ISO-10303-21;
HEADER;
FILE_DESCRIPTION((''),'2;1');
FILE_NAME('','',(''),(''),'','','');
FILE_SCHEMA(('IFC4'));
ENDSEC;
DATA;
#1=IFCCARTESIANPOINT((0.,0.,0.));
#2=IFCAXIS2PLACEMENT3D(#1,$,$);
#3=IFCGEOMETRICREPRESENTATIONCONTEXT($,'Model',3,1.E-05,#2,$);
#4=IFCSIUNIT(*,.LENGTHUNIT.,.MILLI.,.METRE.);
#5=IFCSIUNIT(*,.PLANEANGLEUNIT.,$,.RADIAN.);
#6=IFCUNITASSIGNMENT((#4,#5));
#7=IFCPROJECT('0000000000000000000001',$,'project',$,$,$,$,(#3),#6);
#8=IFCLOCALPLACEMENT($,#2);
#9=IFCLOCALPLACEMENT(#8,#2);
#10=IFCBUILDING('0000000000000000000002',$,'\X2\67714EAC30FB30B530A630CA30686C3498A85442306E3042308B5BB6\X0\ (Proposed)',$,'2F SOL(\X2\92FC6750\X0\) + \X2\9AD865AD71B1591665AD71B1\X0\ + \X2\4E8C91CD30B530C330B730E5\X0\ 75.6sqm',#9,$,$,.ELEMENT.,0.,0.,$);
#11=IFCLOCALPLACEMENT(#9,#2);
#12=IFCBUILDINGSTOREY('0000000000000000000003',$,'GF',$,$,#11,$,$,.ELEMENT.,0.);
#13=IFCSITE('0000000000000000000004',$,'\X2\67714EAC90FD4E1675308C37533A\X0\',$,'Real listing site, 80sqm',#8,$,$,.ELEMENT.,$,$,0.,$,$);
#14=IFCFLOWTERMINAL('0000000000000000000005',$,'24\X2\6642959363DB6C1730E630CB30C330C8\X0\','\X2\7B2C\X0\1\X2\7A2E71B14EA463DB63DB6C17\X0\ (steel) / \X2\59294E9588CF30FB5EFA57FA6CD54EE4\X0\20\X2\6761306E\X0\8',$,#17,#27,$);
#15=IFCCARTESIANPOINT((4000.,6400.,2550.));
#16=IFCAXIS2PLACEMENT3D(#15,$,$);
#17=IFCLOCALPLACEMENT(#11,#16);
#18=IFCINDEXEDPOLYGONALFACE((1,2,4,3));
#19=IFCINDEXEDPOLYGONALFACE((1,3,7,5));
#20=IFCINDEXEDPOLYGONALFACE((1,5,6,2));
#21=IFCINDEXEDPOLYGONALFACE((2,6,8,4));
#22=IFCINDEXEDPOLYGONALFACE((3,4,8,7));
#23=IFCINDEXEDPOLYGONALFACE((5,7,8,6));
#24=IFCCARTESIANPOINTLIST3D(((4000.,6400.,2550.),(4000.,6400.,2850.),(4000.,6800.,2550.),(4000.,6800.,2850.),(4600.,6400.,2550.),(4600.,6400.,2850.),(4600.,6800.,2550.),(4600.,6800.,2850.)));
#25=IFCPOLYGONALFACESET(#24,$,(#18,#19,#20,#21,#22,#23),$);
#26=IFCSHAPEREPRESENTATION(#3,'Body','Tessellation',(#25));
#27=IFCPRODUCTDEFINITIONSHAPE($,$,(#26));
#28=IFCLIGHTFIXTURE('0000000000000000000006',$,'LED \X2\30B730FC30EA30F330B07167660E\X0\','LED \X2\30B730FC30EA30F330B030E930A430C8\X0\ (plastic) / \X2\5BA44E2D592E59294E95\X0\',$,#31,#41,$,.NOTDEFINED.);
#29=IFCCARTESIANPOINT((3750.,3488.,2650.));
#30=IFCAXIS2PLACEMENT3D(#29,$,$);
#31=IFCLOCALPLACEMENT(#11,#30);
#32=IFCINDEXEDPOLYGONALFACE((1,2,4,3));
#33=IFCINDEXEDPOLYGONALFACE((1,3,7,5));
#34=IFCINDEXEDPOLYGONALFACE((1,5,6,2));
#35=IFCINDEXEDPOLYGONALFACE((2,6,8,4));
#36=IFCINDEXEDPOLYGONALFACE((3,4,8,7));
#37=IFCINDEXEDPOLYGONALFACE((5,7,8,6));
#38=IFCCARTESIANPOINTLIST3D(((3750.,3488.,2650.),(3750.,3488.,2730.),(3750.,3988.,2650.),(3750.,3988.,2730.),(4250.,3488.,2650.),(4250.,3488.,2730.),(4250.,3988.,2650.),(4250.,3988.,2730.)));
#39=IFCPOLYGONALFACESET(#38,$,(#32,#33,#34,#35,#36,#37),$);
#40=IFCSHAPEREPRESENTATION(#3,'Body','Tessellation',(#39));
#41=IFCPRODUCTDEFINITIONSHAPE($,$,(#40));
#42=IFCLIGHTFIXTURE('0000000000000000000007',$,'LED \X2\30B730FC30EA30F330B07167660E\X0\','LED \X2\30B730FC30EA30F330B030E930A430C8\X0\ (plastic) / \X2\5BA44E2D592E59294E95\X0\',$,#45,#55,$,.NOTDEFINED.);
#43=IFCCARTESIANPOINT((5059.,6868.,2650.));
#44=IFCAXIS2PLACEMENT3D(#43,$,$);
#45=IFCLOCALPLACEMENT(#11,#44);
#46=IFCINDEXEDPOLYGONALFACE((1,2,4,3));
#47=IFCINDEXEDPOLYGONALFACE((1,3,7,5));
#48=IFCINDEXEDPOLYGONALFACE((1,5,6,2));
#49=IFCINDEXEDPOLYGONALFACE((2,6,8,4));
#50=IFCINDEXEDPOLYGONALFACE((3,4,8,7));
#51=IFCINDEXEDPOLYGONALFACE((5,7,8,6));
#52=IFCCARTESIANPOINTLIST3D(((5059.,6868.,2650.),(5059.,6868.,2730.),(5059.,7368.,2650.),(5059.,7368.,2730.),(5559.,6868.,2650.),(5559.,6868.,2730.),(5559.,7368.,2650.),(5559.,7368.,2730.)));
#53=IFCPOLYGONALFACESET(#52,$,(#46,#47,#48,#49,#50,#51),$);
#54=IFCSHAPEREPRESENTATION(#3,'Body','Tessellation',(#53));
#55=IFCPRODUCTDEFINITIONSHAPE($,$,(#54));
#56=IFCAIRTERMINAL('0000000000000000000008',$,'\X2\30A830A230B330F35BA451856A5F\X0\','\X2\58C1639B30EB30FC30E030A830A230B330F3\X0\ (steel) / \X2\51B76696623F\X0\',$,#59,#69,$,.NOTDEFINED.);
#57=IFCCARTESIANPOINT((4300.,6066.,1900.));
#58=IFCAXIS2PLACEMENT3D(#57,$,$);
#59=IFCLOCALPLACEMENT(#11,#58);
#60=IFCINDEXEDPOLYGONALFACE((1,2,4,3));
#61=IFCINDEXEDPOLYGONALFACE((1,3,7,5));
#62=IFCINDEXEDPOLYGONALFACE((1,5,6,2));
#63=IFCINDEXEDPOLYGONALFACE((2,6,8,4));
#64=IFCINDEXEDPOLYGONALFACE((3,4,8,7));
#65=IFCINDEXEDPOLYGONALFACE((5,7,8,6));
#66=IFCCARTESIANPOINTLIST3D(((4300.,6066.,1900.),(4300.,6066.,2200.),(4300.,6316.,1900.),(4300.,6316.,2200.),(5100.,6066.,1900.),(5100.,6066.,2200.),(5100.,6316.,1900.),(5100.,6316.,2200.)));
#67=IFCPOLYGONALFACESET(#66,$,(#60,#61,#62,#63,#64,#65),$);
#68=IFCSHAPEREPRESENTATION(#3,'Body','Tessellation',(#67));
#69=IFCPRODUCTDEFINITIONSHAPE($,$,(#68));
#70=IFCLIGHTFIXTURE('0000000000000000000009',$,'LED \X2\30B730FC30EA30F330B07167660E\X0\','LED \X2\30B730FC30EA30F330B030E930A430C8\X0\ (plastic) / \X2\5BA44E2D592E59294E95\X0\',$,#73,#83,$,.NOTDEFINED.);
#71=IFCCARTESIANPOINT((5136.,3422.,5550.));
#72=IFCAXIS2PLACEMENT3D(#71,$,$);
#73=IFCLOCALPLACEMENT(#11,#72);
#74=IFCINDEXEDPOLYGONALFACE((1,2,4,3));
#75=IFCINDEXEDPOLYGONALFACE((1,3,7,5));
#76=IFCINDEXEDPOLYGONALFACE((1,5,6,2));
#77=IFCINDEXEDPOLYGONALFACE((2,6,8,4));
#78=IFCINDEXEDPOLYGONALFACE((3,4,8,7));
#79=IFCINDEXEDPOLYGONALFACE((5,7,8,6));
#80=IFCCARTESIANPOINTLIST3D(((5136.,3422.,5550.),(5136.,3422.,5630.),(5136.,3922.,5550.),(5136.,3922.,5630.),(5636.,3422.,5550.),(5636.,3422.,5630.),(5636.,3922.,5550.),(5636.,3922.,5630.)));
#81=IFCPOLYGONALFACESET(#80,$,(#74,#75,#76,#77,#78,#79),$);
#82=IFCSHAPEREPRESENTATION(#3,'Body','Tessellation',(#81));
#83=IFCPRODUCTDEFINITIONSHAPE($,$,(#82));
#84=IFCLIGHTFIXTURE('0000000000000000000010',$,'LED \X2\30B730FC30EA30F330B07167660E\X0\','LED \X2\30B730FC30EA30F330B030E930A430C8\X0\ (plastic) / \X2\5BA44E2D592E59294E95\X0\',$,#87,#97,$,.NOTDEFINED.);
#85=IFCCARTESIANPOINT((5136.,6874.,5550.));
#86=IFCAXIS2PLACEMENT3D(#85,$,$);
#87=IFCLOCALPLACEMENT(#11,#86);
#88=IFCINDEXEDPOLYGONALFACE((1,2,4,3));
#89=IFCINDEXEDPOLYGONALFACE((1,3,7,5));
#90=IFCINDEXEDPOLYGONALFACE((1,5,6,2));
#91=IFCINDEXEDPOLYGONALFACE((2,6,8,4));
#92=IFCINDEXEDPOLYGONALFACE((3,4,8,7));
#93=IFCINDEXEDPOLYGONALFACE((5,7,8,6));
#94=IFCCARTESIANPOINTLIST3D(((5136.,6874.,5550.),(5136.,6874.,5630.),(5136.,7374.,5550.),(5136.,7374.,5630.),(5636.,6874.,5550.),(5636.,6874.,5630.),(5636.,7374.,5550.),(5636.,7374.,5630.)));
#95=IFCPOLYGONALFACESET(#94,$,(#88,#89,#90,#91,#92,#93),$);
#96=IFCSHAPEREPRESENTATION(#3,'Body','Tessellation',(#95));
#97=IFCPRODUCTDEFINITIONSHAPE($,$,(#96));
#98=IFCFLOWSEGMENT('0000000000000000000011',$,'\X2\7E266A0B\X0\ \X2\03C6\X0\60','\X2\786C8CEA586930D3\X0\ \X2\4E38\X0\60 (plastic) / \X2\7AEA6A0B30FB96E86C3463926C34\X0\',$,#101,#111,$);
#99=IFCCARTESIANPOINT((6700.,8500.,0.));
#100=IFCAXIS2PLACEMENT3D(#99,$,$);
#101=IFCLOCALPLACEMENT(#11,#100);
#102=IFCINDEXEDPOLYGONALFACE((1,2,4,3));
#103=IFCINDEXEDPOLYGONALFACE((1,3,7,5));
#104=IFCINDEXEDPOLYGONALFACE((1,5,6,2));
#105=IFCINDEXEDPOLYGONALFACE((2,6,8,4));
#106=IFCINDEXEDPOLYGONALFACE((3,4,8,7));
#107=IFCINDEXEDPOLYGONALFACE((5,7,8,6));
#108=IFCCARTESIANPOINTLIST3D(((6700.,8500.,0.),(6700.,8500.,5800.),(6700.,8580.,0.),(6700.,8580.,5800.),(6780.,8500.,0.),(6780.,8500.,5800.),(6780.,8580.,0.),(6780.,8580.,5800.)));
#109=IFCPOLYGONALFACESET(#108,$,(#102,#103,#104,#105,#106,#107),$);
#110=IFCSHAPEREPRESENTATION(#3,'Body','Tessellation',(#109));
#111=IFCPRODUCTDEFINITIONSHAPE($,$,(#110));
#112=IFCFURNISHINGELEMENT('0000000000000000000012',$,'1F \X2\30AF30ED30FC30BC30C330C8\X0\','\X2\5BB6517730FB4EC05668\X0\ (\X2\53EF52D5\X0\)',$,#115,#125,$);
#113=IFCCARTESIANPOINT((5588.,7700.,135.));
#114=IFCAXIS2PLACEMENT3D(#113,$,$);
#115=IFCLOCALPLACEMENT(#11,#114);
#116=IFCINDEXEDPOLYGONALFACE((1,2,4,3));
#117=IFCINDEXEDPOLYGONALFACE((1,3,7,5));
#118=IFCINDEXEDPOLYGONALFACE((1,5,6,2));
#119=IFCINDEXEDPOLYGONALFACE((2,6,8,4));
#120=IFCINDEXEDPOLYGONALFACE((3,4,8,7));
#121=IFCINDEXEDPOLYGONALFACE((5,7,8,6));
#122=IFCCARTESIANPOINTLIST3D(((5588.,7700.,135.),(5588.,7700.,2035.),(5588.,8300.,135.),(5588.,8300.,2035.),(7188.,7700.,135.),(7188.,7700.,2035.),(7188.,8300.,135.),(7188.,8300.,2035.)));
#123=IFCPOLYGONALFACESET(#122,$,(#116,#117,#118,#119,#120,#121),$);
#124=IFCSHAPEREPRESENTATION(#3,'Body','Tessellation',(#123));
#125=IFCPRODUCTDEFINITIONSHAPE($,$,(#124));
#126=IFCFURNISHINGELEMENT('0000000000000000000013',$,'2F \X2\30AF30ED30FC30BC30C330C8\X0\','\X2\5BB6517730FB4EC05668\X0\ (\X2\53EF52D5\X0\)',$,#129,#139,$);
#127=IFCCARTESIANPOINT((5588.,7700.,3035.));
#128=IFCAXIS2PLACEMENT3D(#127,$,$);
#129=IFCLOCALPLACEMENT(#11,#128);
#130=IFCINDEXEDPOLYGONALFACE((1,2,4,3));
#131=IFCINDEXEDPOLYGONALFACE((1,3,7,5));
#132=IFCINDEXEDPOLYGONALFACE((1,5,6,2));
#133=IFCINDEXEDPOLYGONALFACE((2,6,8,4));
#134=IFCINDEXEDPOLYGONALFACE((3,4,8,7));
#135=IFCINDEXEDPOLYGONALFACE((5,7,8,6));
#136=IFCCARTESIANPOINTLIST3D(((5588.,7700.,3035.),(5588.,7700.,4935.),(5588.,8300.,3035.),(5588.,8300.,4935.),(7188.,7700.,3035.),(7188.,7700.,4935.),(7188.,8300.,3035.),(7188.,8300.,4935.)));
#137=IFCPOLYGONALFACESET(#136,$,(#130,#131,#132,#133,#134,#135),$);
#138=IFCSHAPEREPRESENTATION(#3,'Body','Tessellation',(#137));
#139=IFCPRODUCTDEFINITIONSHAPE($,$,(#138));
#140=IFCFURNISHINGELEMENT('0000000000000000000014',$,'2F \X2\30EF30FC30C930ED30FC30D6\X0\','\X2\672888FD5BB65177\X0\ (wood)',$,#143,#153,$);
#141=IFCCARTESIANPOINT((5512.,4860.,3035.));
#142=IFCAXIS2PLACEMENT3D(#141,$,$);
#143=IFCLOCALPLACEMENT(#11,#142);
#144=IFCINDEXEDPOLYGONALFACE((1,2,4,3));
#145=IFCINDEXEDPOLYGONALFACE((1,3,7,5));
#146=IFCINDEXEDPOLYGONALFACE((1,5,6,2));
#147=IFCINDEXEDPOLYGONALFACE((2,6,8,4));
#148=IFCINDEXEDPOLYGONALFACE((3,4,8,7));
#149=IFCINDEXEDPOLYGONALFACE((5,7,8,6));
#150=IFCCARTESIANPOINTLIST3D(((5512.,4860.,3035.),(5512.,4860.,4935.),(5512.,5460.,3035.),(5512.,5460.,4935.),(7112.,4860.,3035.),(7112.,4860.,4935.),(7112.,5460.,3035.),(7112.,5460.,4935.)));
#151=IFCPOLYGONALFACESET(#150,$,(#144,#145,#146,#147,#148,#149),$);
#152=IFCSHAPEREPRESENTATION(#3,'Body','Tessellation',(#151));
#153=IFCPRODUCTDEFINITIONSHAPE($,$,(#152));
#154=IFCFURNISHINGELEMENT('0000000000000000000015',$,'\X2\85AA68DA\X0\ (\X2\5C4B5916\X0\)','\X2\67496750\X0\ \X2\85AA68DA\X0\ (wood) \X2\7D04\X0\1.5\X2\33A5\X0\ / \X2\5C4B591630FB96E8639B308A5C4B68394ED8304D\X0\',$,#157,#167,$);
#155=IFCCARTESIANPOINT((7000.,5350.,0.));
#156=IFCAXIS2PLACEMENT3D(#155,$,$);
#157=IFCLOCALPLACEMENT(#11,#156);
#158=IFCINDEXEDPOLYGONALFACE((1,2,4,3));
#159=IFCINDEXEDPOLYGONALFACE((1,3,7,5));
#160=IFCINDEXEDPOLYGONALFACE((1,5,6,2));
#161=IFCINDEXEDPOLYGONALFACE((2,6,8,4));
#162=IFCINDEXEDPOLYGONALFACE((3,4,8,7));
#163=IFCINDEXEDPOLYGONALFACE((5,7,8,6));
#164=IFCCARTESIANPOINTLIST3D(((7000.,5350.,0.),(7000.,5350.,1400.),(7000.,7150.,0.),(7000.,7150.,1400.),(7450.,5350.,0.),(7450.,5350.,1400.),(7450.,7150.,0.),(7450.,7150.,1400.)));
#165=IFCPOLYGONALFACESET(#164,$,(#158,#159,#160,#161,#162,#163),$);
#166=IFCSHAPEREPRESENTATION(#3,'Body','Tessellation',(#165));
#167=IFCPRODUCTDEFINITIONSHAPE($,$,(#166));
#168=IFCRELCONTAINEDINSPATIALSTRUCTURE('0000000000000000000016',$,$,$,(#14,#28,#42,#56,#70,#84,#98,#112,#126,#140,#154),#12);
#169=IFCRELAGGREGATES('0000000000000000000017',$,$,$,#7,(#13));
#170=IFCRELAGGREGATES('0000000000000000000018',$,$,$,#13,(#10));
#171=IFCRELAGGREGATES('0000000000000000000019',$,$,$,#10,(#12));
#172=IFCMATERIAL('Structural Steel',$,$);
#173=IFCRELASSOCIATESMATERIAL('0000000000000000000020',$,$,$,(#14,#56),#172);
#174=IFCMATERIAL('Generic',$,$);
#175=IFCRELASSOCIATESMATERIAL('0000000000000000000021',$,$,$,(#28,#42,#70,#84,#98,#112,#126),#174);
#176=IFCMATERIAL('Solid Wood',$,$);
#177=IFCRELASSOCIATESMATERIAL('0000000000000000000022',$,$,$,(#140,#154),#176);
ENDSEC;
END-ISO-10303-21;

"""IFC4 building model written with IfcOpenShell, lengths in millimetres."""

from ifc_helpers import new_model, si_unit, frame, frame_2d, origin, place, context, project, spatial, rectangle, extrude, material, element, save


model = new_model("IFC4")

# Units and contexts
model_context = context("Model", 3, precision=1e-05, world=origin())
ifc_project = project(units=[si_unit("LENGTHUNIT", "METRE", prefix="MILLI"), si_unit("PLANEANGLEUNIT", "RADIAN")], contexts=[model_context])

# Site, building, storey
site_placement = place(None, origin())
site = spatial("IfcSite", under=ifc_project, at=site_placement, Name="東京都世田谷区", ObjectType="Real listing site, 80sqm", CompositionType="ELEMENT", RefElevation=0.0)
building_placement = place(site_placement, origin())
building = spatial("IfcBuilding", under=site, at=building_placement, Name="東京・サウナと水風呂のある家 (Proposed)", ObjectType="2F SOL(鋼材) + 高断熱外断熱 + 二重サッシュ 75.6sqm", CompositionType="ELEMENT", ElevationOfRefHeight=0.0, ElevationOfTerrain=0.0)
storey_placement = place(building_placement, origin())
storey = spatial("IfcBuildingStorey", under=building, at=storey_placement, Name="GF", CompositionType="ELEMENT", Elevation=0.0)

# Shared definitions
ifc_material_1 = material(Name="Solid Wood")

# Shared definitions
ifc_material_2 = material(Name="Structural Steel")

# Shared definitions
ifc_material_3 = material(Name="Generic")

# Flow terminal
flow_terminal_placement = place(storey_placement, frame((4000.0, 6400.0, 2550.0)))
element("IfcFlowTerminal", 1, at=flow_terminal_placement, inside=storey, material=ifc_material_2, Name="24時間換気ユニット", Description="第1種熱交換換気 (steel) / 天井裏・建基法令20条の8", context=model_context, shape_type="SweptSolid", body=[
    extrude(rectangle(XDim=600.0, YDim=400.0, at=frame_2d((300.0, 200.0))), frame((4000.0, 6400.0, 2550.0)), (0.0, 0.0, 1.0), 300.0),
])

# Light fixtures
light_fixture_1_placement = place(storey_placement, frame((3750.0, 3488.0, 2650.0)))
element("IfcLightFixture", 2, at=light_fixture_1_placement, inside=storey, material=ifc_material_3, Name="LED シーリング照明", Description="LED シーリングライト (plastic) / 室中央天井", PredefinedType="NOTDEFINED", context=model_context, shape_type="SweptSolid", body=[
    extrude(rectangle(XDim=500.0, YDim=500.0, at=frame_2d((250.0, 250.0))), frame((3750.0, 3488.0, 2650.0)), (0.0, 0.0, 1.0), 80.0),
])
light_fixture_2_placement = place(storey_placement, frame((5059.0, 6868.0, 2650.0)))
element("IfcLightFixture", 3, at=light_fixture_2_placement, inside=storey, material=ifc_material_3, Name="LED シーリング照明", Description="LED シーリングライト (plastic) / 室中央天井", PredefinedType="NOTDEFINED", context=model_context, shape_type="SweptSolid", body=[
    extrude(rectangle(XDim=500.0, YDim=500.0, at=frame_2d((250.0, 250.0))), frame((5059.0, 6868.0, 2650.0)), (0.0, 0.0, 1.0), 80.0),
])

# Air terminal
air_terminal_placement = place(storey_placement, frame((4300.0, 6066.0, 1900.0)))
element("IfcAirTerminal", 4, at=air_terminal_placement, inside=storey, material=ifc_material_2, Name="エアコン室内機", Description="壁掛ルームエアコン (steel) / 冷暖房", PredefinedType="NOTDEFINED", context=model_context, shape_type="SweptSolid", body=[
    extrude(rectangle(XDim=800.0, YDim=250.0, at=frame_2d((400.0, 125.0))), frame((4300.0, 6066.0, 1900.0)), (0.0, 0.0, 1.0), 300.0),
])

# Light fixtures
light_fixture_3_placement = place(storey_placement, frame((5136.0, 3422.0, 5550.0)))
element("IfcLightFixture", 5, at=light_fixture_3_placement, inside=storey, material=ifc_material_3, Name="LED シーリング照明", Description="LED シーリングライト (plastic) / 室中央天井", PredefinedType="NOTDEFINED", context=model_context, shape_type="SweptSolid", body=[
    extrude(rectangle(XDim=500.0, YDim=500.0, at=frame_2d((250.0, 250.0))), frame((5136.0, 3422.0, 5550.0)), (0.0, 0.0, 1.0), 80.0),
])
light_fixture_4_placement = place(storey_placement, frame((5136.0, 6874.0, 5550.0)))
element("IfcLightFixture", 6, at=light_fixture_4_placement, inside=storey, material=ifc_material_3, Name="LED シーリング照明", Description="LED シーリングライト (plastic) / 室中央天井", PredefinedType="NOTDEFINED", context=model_context, shape_type="SweptSolid", body=[
    extrude(rectangle(XDim=500.0, YDim=500.0, at=frame_2d((250.0, 250.0))), frame((5136.0, 6874.0, 5550.0)), (0.0, 0.0, 1.0), 80.0),
])

# Flow segment
flow_segment_placement = place(storey_placement, frame((6700.0, 8500.0, 0.0)))
element("IfcFlowSegment", 7, at=flow_segment_placement, inside=storey, material=ifc_material_3, Name="縦樋 φ60", Description="硬質塩ビ 丸60 (plastic) / 竪樋・雨水排水", context=model_context, shape_type="SweptSolid", body=[
    extrude(rectangle(XDim=80.0, YDim=80.0, at=frame_2d((40.0, 40.0))), frame((6700.0, 8500.0, 0.0)), (0.0, 0.0, 1.0), 5800.0),
])

# Furnishing elements
furnishing_1_placement = place(storey_placement, frame((5588.0, 7700.0, 135.0)))
element("IfcFurnishingElement", 8, at=furnishing_1_placement, inside=storey, material=ifc_material_3, Name="1F クローゼット", Description="家具・什器 (可動)", context=model_context, shape_type="SweptSolid", body=[
    extrude(rectangle(XDim=1600.0, YDim=600.0, at=frame_2d((800.0, 300.0))), frame((5588.0, 7700.0, 135.0)), (0.0, 0.0, 1.0), 1900.0),
])
furnishing_2_placement = place(storey_placement, frame((5588.0, 7700.0, 3035.0)))
element("IfcFurnishingElement", 9, at=furnishing_2_placement, inside=storey, material=ifc_material_3, Name="2F クローゼット", Description="家具・什器 (可動)", context=model_context, shape_type="SweptSolid", body=[
    extrude(rectangle(XDim=1600.0, YDim=600.0, at=frame_2d((800.0, 300.0))), frame((5588.0, 7700.0, 3035.0)), (0.0, 0.0, 1.0), 1900.0),
])
furnishing_3_placement = place(storey_placement, frame((5512.0, 4860.0, 3035.0)))
element("IfcFurnishingElement", 10, at=furnishing_3_placement, inside=storey, material=ifc_material_1, Name="2F ワードローブ", Description="木製家具 (wood)", context=model_context, shape_type="SweptSolid", body=[
    extrude(rectangle(XDim=1600.0, YDim=600.0, at=frame_2d((800.0, 300.0))), frame((5512.0, 4860.0, 3035.0)), (0.0, 0.0, 1.0), 1900.0),
])
furnishing_4_placement = place(storey_placement, frame((7000.0, 5350.0, 0.0)))
element("IfcFurnishingElement", 11, at=furnishing_4_placement, inside=storey, material=ifc_material_1, Name="薪棚 (屋外)", Description="杉材 薪棚 (wood) 約1.5㎥ / 屋外・雨掛り屋根付き", context=model_context, shape_type="SweptSolid", body=[
    extrude(rectangle(XDim=450.0, YDim=1800.0, at=frame_2d((225.0, 900.0))), frame((7000.0, 5350.0, 0.0)), (0.0, 0.0, 1.0), 1400.0),
])

save(model, "model.ifc")
